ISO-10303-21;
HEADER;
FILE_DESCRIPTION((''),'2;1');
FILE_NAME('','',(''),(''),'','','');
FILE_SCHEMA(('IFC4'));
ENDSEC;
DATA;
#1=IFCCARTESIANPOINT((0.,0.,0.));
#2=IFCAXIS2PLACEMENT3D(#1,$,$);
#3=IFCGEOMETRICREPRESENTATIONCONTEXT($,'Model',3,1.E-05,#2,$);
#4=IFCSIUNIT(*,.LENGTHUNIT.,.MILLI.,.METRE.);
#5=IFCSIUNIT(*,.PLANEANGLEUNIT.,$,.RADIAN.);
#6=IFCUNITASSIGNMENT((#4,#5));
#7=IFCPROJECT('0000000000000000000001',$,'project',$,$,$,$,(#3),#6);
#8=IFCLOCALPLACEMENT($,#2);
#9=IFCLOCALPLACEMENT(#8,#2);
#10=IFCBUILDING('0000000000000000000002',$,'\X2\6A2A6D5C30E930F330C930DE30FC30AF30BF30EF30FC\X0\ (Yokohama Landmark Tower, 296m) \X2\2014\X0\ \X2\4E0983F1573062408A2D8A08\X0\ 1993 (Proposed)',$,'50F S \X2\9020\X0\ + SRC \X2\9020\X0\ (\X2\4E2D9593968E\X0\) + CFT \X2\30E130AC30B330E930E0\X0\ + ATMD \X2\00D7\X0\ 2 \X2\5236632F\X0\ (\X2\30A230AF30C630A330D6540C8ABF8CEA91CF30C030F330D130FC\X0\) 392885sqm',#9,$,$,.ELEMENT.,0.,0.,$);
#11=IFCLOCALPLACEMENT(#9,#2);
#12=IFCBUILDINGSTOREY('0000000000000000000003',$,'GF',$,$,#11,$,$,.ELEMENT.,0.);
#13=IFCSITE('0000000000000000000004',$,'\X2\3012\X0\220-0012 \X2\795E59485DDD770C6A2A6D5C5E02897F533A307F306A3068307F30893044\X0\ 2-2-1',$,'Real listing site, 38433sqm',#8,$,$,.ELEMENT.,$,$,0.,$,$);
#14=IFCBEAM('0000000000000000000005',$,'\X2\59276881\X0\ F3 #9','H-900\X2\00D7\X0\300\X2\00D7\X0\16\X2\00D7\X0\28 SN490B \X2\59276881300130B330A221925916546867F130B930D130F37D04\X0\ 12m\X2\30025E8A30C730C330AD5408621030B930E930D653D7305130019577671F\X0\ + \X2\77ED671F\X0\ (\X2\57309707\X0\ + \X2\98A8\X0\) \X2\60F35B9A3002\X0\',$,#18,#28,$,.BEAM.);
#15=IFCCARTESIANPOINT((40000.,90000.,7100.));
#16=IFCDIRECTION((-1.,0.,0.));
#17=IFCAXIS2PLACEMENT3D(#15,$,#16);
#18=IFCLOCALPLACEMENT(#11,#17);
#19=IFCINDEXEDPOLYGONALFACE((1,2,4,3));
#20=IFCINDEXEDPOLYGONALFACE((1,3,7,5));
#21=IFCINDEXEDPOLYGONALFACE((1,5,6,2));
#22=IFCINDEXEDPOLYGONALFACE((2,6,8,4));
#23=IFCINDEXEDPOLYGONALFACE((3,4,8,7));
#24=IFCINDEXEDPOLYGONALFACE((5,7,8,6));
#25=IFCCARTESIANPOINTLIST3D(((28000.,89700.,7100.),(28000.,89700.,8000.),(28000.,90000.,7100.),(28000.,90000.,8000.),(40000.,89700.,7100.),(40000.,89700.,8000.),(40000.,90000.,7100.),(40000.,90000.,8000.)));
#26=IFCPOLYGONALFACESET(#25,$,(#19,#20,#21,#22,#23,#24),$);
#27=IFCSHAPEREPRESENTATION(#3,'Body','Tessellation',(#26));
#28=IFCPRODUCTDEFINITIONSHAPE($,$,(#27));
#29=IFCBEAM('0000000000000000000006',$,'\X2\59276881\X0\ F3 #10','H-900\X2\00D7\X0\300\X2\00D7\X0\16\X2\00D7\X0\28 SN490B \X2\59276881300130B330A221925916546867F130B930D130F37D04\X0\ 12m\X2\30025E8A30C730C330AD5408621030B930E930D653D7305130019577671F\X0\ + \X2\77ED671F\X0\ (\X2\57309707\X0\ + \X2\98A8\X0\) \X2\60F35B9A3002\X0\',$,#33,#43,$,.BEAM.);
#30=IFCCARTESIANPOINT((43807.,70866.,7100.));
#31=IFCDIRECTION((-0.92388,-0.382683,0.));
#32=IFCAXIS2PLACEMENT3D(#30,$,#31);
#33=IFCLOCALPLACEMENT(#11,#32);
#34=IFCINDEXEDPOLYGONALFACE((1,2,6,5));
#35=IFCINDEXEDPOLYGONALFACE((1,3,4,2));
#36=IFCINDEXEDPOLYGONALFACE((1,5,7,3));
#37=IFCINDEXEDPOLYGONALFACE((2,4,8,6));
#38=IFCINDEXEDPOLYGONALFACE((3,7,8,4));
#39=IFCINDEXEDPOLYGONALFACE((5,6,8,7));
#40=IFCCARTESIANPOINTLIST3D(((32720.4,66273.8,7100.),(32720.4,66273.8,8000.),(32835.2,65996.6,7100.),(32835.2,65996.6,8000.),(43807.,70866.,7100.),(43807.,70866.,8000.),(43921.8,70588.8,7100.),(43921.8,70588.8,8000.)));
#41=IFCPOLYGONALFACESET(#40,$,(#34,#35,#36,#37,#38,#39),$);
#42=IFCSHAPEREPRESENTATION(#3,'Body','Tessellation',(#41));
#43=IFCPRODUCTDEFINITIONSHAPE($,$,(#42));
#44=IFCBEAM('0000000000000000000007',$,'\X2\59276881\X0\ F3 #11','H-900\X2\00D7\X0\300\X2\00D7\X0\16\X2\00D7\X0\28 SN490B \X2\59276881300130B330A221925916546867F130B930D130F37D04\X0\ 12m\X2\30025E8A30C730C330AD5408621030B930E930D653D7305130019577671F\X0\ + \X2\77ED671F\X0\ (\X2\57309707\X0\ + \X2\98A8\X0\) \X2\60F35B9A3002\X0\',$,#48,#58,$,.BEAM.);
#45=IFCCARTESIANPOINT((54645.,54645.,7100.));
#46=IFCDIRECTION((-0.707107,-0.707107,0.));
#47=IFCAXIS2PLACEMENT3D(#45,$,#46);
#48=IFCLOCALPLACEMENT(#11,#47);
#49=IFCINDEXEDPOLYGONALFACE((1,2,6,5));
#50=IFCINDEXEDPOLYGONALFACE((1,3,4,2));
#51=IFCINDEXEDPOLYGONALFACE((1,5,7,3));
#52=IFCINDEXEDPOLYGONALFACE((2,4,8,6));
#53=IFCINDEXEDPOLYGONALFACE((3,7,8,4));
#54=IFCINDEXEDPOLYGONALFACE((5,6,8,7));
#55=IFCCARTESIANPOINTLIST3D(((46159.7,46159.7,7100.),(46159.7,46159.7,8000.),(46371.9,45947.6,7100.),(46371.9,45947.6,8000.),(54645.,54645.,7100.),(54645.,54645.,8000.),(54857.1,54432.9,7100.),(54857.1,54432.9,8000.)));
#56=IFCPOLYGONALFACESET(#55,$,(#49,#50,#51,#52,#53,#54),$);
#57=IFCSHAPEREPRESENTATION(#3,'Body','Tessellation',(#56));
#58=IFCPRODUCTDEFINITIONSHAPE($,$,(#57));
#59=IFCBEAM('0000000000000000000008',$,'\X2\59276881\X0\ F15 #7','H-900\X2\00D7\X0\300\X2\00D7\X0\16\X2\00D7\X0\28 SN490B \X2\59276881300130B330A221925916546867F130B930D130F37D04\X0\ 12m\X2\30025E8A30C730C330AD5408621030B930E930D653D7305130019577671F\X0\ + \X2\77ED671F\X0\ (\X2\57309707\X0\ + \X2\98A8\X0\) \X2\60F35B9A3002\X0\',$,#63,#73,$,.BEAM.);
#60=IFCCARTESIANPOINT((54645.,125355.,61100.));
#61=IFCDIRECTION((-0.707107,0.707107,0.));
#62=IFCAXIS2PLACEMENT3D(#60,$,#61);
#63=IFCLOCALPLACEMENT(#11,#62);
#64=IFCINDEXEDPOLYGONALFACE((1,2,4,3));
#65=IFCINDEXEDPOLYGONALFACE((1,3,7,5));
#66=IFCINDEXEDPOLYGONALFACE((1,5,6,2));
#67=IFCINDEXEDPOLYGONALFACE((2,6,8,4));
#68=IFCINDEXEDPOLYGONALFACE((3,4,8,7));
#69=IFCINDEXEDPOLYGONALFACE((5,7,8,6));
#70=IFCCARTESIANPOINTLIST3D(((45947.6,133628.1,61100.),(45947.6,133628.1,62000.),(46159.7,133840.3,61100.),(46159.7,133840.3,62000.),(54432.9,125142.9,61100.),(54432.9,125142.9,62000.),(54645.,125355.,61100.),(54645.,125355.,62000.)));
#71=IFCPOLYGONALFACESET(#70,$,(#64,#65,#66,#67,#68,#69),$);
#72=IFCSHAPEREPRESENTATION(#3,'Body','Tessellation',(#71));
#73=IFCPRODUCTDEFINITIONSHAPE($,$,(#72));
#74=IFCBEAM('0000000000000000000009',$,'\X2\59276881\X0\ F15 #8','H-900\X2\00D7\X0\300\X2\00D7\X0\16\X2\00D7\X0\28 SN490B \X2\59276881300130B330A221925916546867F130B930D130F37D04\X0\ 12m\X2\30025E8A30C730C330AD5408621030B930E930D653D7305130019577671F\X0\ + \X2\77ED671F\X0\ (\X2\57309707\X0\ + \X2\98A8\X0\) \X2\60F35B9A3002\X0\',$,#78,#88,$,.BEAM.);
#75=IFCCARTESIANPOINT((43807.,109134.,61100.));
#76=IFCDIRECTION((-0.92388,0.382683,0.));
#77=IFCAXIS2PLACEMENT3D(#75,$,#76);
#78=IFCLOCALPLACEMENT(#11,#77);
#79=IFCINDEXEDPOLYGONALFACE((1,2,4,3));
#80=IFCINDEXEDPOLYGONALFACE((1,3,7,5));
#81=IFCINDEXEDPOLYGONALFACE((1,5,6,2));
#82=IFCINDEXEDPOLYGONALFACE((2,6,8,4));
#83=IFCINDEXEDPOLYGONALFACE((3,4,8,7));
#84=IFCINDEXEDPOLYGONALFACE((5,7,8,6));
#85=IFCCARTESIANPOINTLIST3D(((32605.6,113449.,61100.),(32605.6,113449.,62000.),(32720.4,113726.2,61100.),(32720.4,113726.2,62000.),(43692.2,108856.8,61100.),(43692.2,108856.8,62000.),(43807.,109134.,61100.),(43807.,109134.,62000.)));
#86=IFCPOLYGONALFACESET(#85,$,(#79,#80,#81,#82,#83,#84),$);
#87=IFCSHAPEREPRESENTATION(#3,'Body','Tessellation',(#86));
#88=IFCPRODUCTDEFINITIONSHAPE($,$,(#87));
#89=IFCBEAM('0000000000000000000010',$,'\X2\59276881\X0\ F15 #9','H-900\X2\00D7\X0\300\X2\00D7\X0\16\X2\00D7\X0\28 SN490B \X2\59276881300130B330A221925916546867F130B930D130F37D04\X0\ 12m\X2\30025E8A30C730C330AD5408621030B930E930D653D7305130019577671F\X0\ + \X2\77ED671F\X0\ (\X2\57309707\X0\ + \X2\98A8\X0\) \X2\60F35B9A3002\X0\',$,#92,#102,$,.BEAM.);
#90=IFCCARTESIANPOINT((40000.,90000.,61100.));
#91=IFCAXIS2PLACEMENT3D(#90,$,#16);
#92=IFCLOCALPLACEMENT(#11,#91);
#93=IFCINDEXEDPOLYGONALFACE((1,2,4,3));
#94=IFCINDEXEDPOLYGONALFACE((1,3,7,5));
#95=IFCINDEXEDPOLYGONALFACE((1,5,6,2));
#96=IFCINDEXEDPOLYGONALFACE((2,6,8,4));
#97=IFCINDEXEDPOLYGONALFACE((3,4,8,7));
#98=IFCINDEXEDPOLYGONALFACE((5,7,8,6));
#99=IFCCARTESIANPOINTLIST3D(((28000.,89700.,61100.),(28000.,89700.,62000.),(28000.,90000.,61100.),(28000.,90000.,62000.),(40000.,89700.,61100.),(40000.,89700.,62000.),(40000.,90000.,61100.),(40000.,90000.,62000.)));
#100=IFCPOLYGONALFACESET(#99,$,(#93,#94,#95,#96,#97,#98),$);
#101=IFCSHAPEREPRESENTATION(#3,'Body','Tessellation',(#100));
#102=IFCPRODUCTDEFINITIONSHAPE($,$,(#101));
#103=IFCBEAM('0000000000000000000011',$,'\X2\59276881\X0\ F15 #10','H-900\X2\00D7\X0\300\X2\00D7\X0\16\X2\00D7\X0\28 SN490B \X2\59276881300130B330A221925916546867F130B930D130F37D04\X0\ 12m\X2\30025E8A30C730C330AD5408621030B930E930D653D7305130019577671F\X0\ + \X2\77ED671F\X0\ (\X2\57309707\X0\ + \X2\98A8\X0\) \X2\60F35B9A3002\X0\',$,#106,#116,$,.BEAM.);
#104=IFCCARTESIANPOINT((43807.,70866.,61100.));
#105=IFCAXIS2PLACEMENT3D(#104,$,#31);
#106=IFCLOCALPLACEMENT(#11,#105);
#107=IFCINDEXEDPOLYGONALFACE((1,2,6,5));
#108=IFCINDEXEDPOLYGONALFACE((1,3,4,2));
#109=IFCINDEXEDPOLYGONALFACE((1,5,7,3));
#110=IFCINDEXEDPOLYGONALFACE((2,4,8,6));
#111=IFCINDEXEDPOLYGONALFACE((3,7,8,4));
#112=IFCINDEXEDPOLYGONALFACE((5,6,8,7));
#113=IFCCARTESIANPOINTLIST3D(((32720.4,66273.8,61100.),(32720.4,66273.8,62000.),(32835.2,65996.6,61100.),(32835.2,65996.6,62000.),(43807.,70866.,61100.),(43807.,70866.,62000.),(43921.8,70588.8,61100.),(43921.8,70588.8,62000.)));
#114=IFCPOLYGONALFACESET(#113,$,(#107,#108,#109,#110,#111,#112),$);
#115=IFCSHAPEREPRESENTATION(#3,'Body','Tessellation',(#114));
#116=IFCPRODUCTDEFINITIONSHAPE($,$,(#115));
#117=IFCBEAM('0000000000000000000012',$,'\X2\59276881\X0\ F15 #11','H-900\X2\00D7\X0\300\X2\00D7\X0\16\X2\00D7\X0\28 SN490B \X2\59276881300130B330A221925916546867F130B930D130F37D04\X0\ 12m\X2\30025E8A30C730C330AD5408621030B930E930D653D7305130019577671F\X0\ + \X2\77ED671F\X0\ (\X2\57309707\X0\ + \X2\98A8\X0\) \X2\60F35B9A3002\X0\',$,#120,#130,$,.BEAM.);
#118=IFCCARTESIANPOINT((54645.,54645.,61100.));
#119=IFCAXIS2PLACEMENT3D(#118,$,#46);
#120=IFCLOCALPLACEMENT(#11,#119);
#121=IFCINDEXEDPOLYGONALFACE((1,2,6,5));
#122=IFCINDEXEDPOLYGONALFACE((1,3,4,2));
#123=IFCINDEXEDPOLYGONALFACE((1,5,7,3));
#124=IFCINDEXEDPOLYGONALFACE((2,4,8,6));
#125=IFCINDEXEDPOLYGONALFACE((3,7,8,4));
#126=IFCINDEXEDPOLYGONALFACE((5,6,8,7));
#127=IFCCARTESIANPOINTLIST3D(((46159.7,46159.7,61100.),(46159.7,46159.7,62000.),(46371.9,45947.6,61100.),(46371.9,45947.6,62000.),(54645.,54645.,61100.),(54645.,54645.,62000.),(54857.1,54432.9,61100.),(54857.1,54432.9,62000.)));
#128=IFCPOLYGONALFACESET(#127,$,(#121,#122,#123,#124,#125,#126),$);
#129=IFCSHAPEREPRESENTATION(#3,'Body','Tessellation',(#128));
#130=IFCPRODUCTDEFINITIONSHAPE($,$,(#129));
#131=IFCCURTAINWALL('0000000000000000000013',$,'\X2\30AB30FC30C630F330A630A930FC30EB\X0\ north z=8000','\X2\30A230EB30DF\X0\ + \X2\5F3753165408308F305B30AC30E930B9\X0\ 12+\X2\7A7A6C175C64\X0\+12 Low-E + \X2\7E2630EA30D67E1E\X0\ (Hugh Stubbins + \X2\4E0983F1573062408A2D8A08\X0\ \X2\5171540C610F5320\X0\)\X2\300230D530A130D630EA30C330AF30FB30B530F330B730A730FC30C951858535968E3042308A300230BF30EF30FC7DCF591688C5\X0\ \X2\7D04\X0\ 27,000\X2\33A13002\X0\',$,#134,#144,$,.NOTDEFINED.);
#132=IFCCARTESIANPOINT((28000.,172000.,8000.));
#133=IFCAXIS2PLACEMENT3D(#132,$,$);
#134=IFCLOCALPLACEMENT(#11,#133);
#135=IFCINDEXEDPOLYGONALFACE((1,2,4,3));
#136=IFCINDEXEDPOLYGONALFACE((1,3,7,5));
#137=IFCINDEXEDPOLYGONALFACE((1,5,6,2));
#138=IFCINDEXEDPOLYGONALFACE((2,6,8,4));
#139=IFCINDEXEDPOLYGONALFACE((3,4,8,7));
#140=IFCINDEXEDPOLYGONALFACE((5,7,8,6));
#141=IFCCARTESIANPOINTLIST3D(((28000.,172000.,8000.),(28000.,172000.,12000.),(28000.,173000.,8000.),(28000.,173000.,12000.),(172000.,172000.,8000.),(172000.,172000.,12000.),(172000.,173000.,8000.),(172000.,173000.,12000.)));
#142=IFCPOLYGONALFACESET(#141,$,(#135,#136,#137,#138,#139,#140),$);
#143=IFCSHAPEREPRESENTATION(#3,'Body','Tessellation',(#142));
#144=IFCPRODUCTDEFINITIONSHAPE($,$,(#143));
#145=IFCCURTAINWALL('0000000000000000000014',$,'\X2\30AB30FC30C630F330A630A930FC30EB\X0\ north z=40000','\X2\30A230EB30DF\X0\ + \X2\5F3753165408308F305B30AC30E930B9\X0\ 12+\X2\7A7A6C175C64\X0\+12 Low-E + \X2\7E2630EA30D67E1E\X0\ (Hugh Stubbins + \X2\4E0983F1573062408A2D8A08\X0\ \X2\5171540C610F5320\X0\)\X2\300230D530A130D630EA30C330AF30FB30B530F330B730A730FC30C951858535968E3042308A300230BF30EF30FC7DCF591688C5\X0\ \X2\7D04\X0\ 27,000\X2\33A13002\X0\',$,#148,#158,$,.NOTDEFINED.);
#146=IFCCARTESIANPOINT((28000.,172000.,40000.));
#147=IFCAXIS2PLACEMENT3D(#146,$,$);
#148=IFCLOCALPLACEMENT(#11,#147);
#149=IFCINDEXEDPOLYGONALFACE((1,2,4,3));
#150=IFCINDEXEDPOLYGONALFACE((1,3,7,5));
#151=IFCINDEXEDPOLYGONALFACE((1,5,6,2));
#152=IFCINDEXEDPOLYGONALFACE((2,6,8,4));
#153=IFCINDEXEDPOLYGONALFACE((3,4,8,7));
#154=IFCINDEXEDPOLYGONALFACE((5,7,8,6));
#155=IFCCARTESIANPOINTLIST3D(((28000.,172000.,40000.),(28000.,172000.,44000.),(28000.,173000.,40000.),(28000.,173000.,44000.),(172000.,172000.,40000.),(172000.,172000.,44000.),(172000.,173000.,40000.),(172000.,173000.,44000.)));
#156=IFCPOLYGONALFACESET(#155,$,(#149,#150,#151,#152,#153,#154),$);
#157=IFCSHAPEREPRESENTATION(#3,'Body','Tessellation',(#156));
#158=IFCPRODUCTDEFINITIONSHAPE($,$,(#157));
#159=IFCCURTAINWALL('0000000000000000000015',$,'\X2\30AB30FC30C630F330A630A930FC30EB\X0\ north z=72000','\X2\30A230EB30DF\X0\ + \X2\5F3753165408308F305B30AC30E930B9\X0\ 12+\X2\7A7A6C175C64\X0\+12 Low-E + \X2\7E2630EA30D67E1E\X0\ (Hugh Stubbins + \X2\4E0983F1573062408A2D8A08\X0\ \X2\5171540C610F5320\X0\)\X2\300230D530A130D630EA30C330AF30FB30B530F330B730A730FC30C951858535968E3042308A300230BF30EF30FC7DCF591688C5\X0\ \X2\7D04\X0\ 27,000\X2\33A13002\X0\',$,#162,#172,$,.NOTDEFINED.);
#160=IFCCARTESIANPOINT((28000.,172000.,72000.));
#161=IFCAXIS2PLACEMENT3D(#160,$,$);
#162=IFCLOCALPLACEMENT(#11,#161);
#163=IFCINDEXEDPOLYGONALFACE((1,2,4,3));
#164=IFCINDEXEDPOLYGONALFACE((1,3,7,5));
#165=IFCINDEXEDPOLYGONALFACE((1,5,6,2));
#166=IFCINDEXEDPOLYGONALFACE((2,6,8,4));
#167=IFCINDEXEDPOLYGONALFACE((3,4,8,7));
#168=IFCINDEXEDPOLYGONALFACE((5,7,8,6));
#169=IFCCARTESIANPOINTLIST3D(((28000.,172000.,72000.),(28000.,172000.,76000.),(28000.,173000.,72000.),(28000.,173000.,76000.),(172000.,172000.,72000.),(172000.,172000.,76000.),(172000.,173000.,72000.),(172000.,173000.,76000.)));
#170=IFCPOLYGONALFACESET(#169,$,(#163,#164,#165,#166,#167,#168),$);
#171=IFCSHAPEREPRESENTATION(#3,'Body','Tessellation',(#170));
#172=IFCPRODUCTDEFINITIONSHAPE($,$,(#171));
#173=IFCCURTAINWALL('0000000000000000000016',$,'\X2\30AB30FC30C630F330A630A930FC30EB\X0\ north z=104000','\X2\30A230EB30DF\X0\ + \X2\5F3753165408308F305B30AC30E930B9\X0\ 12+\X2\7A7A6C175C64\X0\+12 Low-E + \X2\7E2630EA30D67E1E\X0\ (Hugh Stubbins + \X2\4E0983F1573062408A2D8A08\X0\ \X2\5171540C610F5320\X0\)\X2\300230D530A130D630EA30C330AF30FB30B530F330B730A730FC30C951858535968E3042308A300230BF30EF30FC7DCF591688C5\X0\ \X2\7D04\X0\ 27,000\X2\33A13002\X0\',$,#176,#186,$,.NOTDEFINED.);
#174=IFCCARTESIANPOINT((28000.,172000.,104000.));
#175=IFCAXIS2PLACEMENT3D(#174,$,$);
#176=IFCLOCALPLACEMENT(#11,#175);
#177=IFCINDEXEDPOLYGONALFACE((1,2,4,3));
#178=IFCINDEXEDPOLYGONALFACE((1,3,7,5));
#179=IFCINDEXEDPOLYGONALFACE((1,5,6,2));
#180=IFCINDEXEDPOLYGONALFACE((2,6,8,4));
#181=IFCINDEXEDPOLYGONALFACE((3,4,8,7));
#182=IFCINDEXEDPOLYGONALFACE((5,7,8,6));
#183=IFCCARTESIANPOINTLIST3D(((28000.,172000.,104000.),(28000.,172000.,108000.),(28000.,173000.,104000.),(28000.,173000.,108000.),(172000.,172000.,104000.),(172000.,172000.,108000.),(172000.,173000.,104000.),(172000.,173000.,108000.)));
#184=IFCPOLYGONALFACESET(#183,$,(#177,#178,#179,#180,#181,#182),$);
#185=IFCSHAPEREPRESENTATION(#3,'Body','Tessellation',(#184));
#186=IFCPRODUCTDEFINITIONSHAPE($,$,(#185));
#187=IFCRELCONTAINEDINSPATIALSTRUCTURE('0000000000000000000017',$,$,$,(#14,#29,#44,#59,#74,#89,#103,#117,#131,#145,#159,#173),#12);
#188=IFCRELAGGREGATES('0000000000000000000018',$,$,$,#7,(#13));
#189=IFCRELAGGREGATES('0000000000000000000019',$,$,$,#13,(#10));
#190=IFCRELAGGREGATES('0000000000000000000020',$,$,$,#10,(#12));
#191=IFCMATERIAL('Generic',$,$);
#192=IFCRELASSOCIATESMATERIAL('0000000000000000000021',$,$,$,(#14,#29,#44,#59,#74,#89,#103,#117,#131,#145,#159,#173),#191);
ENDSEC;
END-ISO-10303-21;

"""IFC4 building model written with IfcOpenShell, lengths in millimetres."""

from ifc_helpers import new_model, si_unit, frame, frame_2d, origin, place, context, project, spatial, rectangle, extrude, material, element, save


model = new_model("IFC4")

# Units and contexts
model_context = context("Model", 3, precision=1e-05, world=origin())
ifc_project = project(units=[si_unit("LENGTHUNIT", "METRE", prefix="MILLI"), si_unit("PLANEANGLEUNIT", "RADIAN")], contexts=[model_context])

# Site, building, storey
site_placement = place(None, origin())
site = spatial("IfcSite", under=ifc_project, at=site_placement, Name="〒220-0012 神奈川県横浜市西区みなとみらい 2-2-1", ObjectType="Real listing site, 38433sqm", CompositionType="ELEMENT", RefElevation=0.0)
building_placement = place(site_placement, origin())
building = spatial("IfcBuilding", under=site, at=building_placement, Name="横浜ランドマークタワー (Yokohama Landmark Tower, 296m) — 三菱地所設計 1993 (Proposed)", ObjectType="50F S 造 + SRC 造 (中間階) + CFT メガコラム + ATMD × 2 制振 (アクティブ同調質量ダンパー) 392885sqm", CompositionType="ELEMENT", ElevationOfRefHeight=0.0, ElevationOfTerrain=0.0)
storey_placement = place(building_placement, origin())
storey = spatial("IfcBuildingStorey", under=building, at=storey_placement, Name="GF", CompositionType="ELEMENT", Elevation=0.0)

# Beams
ifc_material_1 = material(Name="Generic")
beam_1_placement = place(storey_placement, frame((40000.0, 90000.0, 7100.0), x_axis=(-1.0, 0.0, 0.0)))
element("IfcBeam", 1, at=beam_1_placement, inside=storey, material=ifc_material_1, Name="大梁 F3 #9", Description="H-900×300×16×28 SN490B 大梁、コア→外周柱スパン約 12m。床デッキ合成スラブ受け、長期 + 短期 (地震 + 風) 想定。", PredefinedType="BEAM", context=model_context, shape_type="SweptSolid", body=[
    extrude(rectangle(XDim=12000.0, YDim=300.0, at=frame_2d((6000.0, 150.0))), frame((40000.0, 90000.0, 7100.0), x_axis=(-1.0, 0.0, 0.0)), (0.0, 0.0, 1.0), 900.0),
])
beam_2_placement = place(storey_placement, frame((43807.0, 70866.0, 7100.0), x_axis=(-0.92388, -0.382683, 0.0)))
element("IfcBeam", 2, at=beam_2_placement, inside=storey, material=ifc_material_1, Name="大梁 F3 #10", Description="H-900×300×16×28 SN490B 大梁、コア→外周柱スパン約 12m。床デッキ合成スラブ受け、長期 + 短期 (地震 + 風) 想定。", PredefinedType="BEAM", context=model_context, shape_type="SweptSolid", body=[
    extrude(rectangle(XDim=12000.0, YDim=300.0, at=frame_2d((6000.0, 150.0))), frame((43807.0, 70866.0, 7100.0), x_axis=(-0.92388, -0.382683, 0.0)), (0.0, 0.0, 1.0), 900.0),
])
beam_3_placement = place(storey_placement, frame((54645.0, 54645.0, 7100.0), x_axis=(-0.707107, -0.707107, 0.0)))
element("IfcBeam", 3, at=beam_3_placement, inside=storey, material=ifc_material_1, Name="大梁 F3 #11", Description="H-900×300×16×28 SN490B 大梁、コア→外周柱スパン約 12m。床デッキ合成スラブ受け、長期 + 短期 (地震 + 風) 想定。", PredefinedType="BEAM", context=model_context, shape_type="SweptSolid", body=[
    extrude(rectangle(XDim=12000.0, YDim=300.0, at=frame_2d((6000.0, 150.0))), frame((54645.0, 54645.0, 7100.0), x_axis=(-0.707107, -0.707107, 0.0)), (0.0, 0.0, 1.0), 900.0),
])
beam_4_placement = place(storey_placement, frame((54645.0, 125355.0, 61100.0), x_axis=(-0.707107, 0.707107, 0.0)))
element("IfcBeam", 4, at=beam_4_placement, inside=storey, material=ifc_material_1, Name="大梁 F15 #7", Description="H-900×300×16×28 SN490B 大梁、コア→外周柱スパン約 12m。床デッキ合成スラブ受け、長期 + 短期 (地震 + 風) 想定。", PredefinedType="BEAM", context=model_context, shape_type="SweptSolid", body=[
    extrude(rectangle(XDim=12000.0, YDim=300.0, at=frame_2d((6000.0, 150.0))), frame((54645.0, 125355.0, 61100.0), x_axis=(-0.707107, 0.707107, 0.0)), (0.0, 0.0, 1.0), 900.0),
])
beam_5_placement = place(storey_placement, frame((43807.0, 109134.0, 61100.0), x_axis=(-0.92388, 0.382683, 0.0)))
element("IfcBeam", 5, at=beam_5_placement, inside=storey, material=ifc_material_1, Name="大梁 F15 #8", Description="H-900×300×16×28 SN490B 大梁、コア→外周柱スパン約 12m。床デッキ合成スラブ受け、長期 + 短期 (地震 + 風) 想定。", PredefinedType="BEAM", context=model_context, shape_type="SweptSolid", body=[
    extrude(rectangle(XDim=12000.0, YDim=300.0, at=frame_2d((6000.0, 150.0))), frame((43807.0, 109134.0, 61100.0), x_axis=(-0.92388, 0.382683, 0.0)), (0.0, 0.0, 1.0), 900.0),
])
beam_6_placement = place(storey_placement, frame((40000.0, 90000.0, 61100.0), x_axis=(-1.0, 0.0, 0.0)))
element("IfcBeam", 6, at=beam_6_placement, inside=storey, material=ifc_material_1, Name="大梁 F15 #9", Description="H-900×300×16×28 SN490B 大梁、コア→外周柱スパン約 12m。床デッキ合成スラブ受け、長期 + 短期 (地震 + 風) 想定。", PredefinedType="BEAM", context=model_context, shape_type="SweptSolid", body=[
    extrude(rectangle(XDim=12000.0, YDim=300.0, at=frame_2d((6000.0, 150.0))), frame((40000.0, 90000.0, 61100.0), x_axis=(-1.0, 0.0, 0.0)), (0.0, 0.0, 1.0), 900.0),
])
beam_7_placement = place(storey_placement, frame((43807.0, 70866.0, 61100.0), x_axis=(-0.92388, -0.382683, 0.0)))
element("IfcBeam", 7, at=beam_7_placement, inside=storey, material=ifc_material_1, Name="大梁 F15 #10", Description="H-900×300×16×28 SN490B 大梁、コア→外周柱スパン約 12m。床デッキ合成スラブ受け、長期 + 短期 (地震 + 風) 想定。", PredefinedType="BEAM", context=model_context, shape_type="SweptSolid", body=[
    extrude(rectangle(XDim=12000.0, YDim=300.0, at=frame_2d((6000.0, 150.0))), frame((43807.0, 70866.0, 61100.0), x_axis=(-0.92388, -0.382683, 0.0)), (0.0, 0.0, 1.0), 900.0),
])
beam_8_placement = place(storey_placement, frame((54645.0, 54645.0, 61100.0), x_axis=(-0.707107, -0.707107, 0.0)))
element("IfcBeam", 8, at=beam_8_placement, inside=storey, material=ifc_material_1, Name="大梁 F15 #11", Description="H-900×300×16×28 SN490B 大梁、コア→外周柱スパン約 12m。床デッキ合成スラブ受け、長期 + 短期 (地震 + 風) 想定。", PredefinedType="BEAM", context=model_context, shape_type="SweptSolid", body=[
    extrude(rectangle(XDim=12000.0, YDim=300.0, at=frame_2d((6000.0, 150.0))), frame((54645.0, 54645.0, 61100.0), x_axis=(-0.707107, -0.707107, 0.0)), (0.0, 0.0, 1.0), 900.0),
])

# Curtain walls
curtain_wall_1_placement = place(storey_placement, frame((28000.0, 172000.0, 8000.0)))
element("IfcCurtainWall", 9, at=curtain_wall_1_placement, inside=storey, material=ifc_material_1, Name="カーテンウォール north z=8000", Description="アルミ + 強化合わせガラス 12+空気層+12 Low-E + 縦リブ縞 (Hugh Stubbins + 三菱地所設計 共同意匠)。ファブリック・サンシェード内蔵階あり。タワー総外装 約 27,000㎡。", PredefinedType="NOTDEFINED", context=model_context, shape_type="SweptSolid", body=[
    extrude(rectangle(XDim=144000.0, YDim=1000.0, at=frame_2d((72000.0, 500.0))), frame((28000.0, 172000.0, 8000.0)), (0.0, 0.0, 1.0), 4000.0),
])
curtain_wall_2_placement = place(storey_placement, frame((28000.0, 172000.0, 40000.0)))
element("IfcCurtainWall", 10, at=curtain_wall_2_placement, inside=storey, material=ifc_material_1, Name="カーテンウォール north z=40000", Description="アルミ + 強化合わせガラス 12+空気層+12 Low-E + 縦リブ縞 (Hugh Stubbins + 三菱地所設計 共同意匠)。ファブリック・サンシェード内蔵階あり。タワー総外装 約 27,000㎡。", PredefinedType="NOTDEFINED", context=model_context, shape_type="SweptSolid", body=[
    extrude(rectangle(XDim=144000.0, YDim=1000.0, at=frame_2d((72000.0, 500.0))), frame((28000.0, 172000.0, 40000.0)), (0.0, 0.0, 1.0), 4000.0),
])
curtain_wall_3_placement = place(storey_placement, frame((28000.0, 172000.0, 72000.0)))
element("IfcCurtainWall", 11, at=curtain_wall_3_placement, inside=storey, material=ifc_material_1, Name="カーテンウォール north z=72000", Description="アルミ + 強化合わせガラス 12+空気層+12 Low-E + 縦リブ縞 (Hugh Stubbins + 三菱地所設計 共同意匠)。ファブリック・サンシェード内蔵階あり。タワー総外装 約 27,000㎡。", PredefinedType="NOTDEFINED", context=model_context, shape_type="SweptSolid", body=[
    extrude(rectangle(XDim=144000.0, YDim=1000.0, at=frame_2d((72000.0, 500.0))), frame((28000.0, 172000.0, 72000.0)), (0.0, 0.0, 1.0), 4000.0),
])
curtain_wall_4_placement = place(storey_placement, frame((28000.0, 172000.0, 104000.0)))
element("IfcCurtainWall", 12, at=curtain_wall_4_placement, inside=storey, material=ifc_material_1, Name="カーテンウォール north z=104000", Description="アルミ + 強化合わせガラス 12+空気層+12 Low-E + 縦リブ縞 (Hugh Stubbins + 三菱地所設計 共同意匠)。ファブリック・サンシェード内蔵階あり。タワー総外装 約 27,000㎡。", PredefinedType="NOTDEFINED", context=model_context, shape_type="SweptSolid", body=[
    extrude(rectangle(XDim=144000.0, YDim=1000.0, at=frame_2d((72000.0, 500.0))), frame((28000.0, 172000.0, 104000.0)), (0.0, 0.0, 1.0), 4000.0),
])

save(model, "model.ifc")
